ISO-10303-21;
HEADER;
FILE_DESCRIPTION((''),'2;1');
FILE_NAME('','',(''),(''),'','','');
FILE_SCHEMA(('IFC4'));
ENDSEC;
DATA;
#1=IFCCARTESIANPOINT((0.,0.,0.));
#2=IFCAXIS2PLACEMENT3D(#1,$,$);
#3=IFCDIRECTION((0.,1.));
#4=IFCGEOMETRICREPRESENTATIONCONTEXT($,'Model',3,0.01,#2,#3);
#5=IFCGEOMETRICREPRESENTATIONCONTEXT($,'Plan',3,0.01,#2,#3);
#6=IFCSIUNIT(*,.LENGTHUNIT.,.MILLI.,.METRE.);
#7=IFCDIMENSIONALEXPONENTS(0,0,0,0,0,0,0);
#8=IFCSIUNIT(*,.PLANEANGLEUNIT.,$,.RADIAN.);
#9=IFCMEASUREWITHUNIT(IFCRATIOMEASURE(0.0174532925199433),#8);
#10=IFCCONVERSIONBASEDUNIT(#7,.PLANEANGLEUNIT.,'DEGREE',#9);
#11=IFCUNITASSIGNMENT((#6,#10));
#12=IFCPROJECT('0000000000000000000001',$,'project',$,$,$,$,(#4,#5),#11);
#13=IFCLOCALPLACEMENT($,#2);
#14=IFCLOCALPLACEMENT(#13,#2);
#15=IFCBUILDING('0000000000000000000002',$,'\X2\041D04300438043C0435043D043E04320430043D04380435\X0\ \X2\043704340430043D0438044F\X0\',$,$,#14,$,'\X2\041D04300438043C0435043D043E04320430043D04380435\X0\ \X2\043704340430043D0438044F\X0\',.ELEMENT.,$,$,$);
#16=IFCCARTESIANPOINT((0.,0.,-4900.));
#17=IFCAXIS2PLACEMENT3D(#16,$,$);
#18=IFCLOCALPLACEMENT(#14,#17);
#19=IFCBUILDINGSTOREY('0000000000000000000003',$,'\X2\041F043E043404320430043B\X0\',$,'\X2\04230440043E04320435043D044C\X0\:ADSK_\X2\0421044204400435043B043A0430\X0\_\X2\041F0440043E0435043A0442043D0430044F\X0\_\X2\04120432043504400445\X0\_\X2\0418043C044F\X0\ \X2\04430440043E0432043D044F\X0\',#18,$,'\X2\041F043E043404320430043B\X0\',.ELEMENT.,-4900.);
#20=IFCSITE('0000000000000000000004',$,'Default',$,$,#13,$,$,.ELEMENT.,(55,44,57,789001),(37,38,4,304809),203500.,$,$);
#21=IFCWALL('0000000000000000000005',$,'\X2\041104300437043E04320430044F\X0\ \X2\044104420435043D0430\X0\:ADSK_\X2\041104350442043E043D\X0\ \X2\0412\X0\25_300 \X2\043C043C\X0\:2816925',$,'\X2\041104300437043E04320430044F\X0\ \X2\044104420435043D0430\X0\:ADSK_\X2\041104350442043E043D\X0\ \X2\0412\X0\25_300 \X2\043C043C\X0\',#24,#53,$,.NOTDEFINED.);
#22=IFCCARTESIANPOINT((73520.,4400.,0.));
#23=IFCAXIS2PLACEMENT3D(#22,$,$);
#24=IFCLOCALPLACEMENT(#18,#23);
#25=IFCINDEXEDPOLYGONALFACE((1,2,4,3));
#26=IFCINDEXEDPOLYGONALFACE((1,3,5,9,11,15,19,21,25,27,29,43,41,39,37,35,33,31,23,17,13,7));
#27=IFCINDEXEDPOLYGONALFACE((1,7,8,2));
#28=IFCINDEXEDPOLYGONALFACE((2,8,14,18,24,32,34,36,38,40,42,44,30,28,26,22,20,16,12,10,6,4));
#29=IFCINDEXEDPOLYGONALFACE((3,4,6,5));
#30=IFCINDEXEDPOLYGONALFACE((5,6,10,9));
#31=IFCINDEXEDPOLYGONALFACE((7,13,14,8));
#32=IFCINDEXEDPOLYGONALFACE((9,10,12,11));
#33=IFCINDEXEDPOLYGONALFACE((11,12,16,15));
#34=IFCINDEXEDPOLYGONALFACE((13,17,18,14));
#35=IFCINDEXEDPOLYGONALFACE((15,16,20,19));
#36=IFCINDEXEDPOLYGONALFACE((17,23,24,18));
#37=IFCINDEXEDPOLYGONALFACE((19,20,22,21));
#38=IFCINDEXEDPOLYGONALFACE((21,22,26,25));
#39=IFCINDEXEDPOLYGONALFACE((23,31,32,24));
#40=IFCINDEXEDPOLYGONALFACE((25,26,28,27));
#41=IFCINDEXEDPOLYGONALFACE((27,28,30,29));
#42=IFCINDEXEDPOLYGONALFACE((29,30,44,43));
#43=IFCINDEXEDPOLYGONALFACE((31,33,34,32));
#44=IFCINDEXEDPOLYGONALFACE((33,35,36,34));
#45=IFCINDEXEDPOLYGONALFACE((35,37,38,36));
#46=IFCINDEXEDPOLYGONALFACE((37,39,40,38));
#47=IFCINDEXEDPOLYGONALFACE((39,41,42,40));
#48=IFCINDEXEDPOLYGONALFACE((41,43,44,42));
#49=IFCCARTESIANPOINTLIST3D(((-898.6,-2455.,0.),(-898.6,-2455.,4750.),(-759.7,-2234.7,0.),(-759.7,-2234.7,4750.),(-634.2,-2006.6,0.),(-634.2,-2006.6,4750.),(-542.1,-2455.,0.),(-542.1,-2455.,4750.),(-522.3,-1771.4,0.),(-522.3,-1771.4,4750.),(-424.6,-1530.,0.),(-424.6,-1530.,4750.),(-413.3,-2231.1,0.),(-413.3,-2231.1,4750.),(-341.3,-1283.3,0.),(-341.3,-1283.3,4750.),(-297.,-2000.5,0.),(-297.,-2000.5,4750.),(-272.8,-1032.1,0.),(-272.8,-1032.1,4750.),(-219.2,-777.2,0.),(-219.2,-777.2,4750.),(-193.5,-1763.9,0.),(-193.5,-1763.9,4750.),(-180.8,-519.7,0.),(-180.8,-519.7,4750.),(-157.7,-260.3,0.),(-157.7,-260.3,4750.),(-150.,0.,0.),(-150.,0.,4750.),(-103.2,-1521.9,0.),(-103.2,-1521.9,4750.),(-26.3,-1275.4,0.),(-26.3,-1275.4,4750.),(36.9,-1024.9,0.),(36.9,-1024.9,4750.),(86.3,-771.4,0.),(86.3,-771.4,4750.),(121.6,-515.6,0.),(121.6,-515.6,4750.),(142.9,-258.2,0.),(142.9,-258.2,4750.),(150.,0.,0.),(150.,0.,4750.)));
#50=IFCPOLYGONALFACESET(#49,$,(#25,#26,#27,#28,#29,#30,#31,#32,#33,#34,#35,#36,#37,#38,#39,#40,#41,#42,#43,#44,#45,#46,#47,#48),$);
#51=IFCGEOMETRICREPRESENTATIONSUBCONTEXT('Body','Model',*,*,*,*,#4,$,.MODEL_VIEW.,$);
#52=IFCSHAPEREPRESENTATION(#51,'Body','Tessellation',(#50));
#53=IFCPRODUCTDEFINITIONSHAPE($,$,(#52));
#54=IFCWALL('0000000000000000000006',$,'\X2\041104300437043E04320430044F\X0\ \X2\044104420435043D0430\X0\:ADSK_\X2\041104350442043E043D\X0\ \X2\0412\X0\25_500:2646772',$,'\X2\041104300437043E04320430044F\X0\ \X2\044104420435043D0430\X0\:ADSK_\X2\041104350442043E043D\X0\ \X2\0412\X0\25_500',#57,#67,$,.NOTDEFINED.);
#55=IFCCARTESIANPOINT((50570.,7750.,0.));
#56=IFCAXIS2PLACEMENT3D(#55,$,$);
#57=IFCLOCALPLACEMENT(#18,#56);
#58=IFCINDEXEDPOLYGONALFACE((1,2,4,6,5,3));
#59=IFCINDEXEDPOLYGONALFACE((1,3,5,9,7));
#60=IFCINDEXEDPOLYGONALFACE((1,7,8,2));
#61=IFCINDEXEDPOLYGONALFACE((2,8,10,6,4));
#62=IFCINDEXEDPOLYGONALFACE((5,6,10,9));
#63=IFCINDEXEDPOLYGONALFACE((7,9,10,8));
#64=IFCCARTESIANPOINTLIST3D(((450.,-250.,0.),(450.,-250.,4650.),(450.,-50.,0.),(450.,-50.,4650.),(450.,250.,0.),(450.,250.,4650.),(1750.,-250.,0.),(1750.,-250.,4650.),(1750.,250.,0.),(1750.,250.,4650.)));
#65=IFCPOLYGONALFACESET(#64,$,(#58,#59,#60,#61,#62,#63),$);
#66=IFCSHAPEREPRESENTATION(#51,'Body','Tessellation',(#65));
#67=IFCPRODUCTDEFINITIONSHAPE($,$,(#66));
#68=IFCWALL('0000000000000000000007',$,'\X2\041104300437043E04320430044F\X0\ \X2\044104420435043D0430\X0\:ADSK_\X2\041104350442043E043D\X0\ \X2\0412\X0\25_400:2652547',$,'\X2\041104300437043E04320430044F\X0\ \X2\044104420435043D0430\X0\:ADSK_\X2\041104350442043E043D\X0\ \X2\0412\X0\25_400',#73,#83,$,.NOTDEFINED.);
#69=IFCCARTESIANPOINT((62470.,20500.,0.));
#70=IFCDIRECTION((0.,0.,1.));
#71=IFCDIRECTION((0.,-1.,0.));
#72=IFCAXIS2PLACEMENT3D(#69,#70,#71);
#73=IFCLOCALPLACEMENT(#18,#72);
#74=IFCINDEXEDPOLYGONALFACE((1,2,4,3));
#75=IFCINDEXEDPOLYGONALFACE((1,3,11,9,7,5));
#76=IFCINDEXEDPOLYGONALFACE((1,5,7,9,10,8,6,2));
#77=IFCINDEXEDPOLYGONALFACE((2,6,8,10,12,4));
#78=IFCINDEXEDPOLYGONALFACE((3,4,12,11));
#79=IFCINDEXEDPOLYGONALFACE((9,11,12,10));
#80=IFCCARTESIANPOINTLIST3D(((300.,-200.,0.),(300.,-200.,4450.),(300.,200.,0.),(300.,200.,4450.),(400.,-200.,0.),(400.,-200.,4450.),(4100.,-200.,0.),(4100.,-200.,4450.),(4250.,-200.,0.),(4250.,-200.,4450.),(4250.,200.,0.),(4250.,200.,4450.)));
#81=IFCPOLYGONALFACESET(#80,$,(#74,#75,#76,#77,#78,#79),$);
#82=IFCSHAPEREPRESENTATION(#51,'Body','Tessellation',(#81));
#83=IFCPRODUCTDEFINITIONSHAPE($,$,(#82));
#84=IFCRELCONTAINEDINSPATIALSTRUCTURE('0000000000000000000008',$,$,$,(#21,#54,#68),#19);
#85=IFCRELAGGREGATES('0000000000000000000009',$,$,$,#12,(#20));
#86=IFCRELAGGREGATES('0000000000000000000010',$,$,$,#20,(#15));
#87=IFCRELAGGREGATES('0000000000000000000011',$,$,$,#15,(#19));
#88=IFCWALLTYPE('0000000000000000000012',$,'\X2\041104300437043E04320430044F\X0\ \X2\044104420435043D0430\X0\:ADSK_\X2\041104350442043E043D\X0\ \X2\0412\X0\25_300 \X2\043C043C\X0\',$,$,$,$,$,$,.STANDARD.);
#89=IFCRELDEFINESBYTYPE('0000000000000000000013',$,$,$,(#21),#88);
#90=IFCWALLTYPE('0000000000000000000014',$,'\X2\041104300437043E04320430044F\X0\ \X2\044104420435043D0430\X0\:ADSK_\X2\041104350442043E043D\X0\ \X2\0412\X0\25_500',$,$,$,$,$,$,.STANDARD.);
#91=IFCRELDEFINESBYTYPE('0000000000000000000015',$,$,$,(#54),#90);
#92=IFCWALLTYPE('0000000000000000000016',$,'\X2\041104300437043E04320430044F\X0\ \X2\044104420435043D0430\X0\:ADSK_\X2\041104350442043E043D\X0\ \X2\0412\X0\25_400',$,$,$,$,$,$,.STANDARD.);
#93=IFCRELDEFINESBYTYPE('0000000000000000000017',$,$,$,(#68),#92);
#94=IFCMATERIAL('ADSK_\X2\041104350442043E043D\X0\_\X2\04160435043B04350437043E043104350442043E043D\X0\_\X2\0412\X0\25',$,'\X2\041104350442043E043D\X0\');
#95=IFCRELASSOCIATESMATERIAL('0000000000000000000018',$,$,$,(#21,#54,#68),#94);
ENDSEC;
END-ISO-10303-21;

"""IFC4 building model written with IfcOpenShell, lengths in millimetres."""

from ifc_helpers import new_model, entity, si_unit, converted_unit, direction, frame, origin, place, context, subcontext, project, spatial, indexed_curve, outline, extrude, material, type_object, element, save


model = new_model("IFC4")

# Units and contexts
model_context = context("Model", 3, precision=0.01, world=origin(), true_north=direction((0.0, 1.0)))
plan_context = context("Plan", 3, precision=0.01, world=origin(), true_north=direction((0.0, 1.0)))
body_context = subcontext(model_context, "Body", "Model", "MODEL_VIEW")
ifc_project = project(units=[si_unit("LENGTHUNIT", "METRE", prefix="MILLI"), converted_unit("PLANEANGLEUNIT", "DEGREE", entity("IfcRatioMeasure", 0.0174532925199433), si_unit("PLANEANGLEUNIT", "RADIAN"), dimensions=[0, 0, 0, 0, 0, 0, 0])], contexts=[model_context, plan_context])

# Site, building, storey
site_placement = place(None, origin())
site = spatial("IfcSite", under=ifc_project, at=site_placement, Name="Default", CompositionType="ELEMENT", RefLatitude=(55, 44, 57, 789001), RefLongitude=(37, 38, 4, 304809), RefElevation=203500.0)
building_placement = place(site_placement, origin())
building = spatial("IfcBuilding", under=site, at=building_placement, Name="Наименование здания", LongName="Наименование здания", CompositionType="ELEMENT")
storey_placement = place(building_placement, frame((0.0, 0.0, -4900.0)))
storey = spatial("IfcBuildingStorey", under=building, at=storey_placement, Name="Подвал", ObjectType="Уровень:ADSK_Стрелка_Проектная_Вверх_Имя уровня", LongName="Подвал", CompositionType="ELEMENT", Elevation=-4900.0)

# Shared definitions
ifc_material = material(Name="ADSK_Бетон_Железобетон_В25", Category="Бетон")

# Walls
wall_type_1 = type_object("IfcWallType", Name="Базовая стена:ADSK_Бетон В25_300 мм", PredefinedType="STANDARD")
wall_1_placement = place(storey_placement, frame((73520.0, 4400.0, 0.0)))
element("IfcWall", 1, at=wall_1_placement, inside=storey, type_object=wall_type_1, material=ifc_material, Name="Базовая стена:ADSK_Бетон В25_300 мм:2816925", ObjectType="Базовая стена:ADSK_Бетон В25_300 мм", PredefinedType="NOTDEFINED", context=body_context, shape_type="SweptSolid", body=[
    extrude(outline(indexed_curve([(-542.1, -2455.0), (-413.3, -2231.1), (-297.0, -2000.5), (-193.5, -1763.9), (-103.2, -1521.9), (-26.3, -1275.4), (36.9, -1024.9), (86.3, -771.4), (121.6, -515.6), (142.9, -258.2), (150.0, 0.0), (-150.0, 0.0), (-157.7, -260.3), (-180.8, -519.7), (-219.2, -777.2), (-272.8, -1032.1), (-341.3, -1283.3), (-424.6, -1530.0), (-522.3, -1771.4), (-634.2, -2006.6), (-759.7, -2234.7), (-898.6, -2455.0), (-542.1, -2455.0)], self_intersect=False)), origin(), (0.0, 0.0, 1.0), 4750.0),
])
wall_type_2 = type_object("IfcWallType", Name="Базовая стена:ADSK_Бетон В25_500", PredefinedType="STANDARD")
wall_2_placement = place(storey_placement, frame((50570.0, 7750.0, 0.0)))
element("IfcWall", 2, at=wall_2_placement, inside=storey, type_object=wall_type_2, material=ifc_material, Name="Базовая стена:ADSK_Бетон В25_500:2646772", ObjectType="Базовая стена:ADSK_Бетон В25_500", PredefinedType="NOTDEFINED", context=body_context, shape_type="SweptSolid", body=[
    extrude(outline(indexed_curve([(1750.0, -250.0), (1750.0, 250.0), (450.0, 250.0), (450.0, -50.0), (450.0, -250.0), (1750.0, -250.0)], self_intersect=False)), origin(), (0.0, 0.0, 1.0), 4650.0),
])
wall_type_3 = type_object("IfcWallType", Name="Базовая стена:ADSK_Бетон В25_400", PredefinedType="STANDARD")
wall_3_placement = place(storey_placement, frame((62470.0, 20500.0, 0.0), z_axis=(0.0, 0.0, 1.0), x_axis=(0.0, -1.0, 0.0)))
element("IfcWall", 3, at=wall_3_placement, inside=storey, type_object=wall_type_3, material=ifc_material, Name="Базовая стена:ADSK_Бетон В25_400:2652547", ObjectType="Базовая стена:ADSK_Бетон В25_400", PredefinedType="NOTDEFINED", context=body_context, shape_type="SweptSolid", body=[
    extrude(outline(indexed_curve([(4250.0, -200.0), (4250.0, 200.0), (300.0, 200.0), (300.0, -200.0), (400.0, -200.0), (4100.0, -200.0), (4250.0, -200.0)], self_intersect=False)), origin(), (0.0, 0.0, 1.0), 4450.0),
])

save(model, "model.ifc")
